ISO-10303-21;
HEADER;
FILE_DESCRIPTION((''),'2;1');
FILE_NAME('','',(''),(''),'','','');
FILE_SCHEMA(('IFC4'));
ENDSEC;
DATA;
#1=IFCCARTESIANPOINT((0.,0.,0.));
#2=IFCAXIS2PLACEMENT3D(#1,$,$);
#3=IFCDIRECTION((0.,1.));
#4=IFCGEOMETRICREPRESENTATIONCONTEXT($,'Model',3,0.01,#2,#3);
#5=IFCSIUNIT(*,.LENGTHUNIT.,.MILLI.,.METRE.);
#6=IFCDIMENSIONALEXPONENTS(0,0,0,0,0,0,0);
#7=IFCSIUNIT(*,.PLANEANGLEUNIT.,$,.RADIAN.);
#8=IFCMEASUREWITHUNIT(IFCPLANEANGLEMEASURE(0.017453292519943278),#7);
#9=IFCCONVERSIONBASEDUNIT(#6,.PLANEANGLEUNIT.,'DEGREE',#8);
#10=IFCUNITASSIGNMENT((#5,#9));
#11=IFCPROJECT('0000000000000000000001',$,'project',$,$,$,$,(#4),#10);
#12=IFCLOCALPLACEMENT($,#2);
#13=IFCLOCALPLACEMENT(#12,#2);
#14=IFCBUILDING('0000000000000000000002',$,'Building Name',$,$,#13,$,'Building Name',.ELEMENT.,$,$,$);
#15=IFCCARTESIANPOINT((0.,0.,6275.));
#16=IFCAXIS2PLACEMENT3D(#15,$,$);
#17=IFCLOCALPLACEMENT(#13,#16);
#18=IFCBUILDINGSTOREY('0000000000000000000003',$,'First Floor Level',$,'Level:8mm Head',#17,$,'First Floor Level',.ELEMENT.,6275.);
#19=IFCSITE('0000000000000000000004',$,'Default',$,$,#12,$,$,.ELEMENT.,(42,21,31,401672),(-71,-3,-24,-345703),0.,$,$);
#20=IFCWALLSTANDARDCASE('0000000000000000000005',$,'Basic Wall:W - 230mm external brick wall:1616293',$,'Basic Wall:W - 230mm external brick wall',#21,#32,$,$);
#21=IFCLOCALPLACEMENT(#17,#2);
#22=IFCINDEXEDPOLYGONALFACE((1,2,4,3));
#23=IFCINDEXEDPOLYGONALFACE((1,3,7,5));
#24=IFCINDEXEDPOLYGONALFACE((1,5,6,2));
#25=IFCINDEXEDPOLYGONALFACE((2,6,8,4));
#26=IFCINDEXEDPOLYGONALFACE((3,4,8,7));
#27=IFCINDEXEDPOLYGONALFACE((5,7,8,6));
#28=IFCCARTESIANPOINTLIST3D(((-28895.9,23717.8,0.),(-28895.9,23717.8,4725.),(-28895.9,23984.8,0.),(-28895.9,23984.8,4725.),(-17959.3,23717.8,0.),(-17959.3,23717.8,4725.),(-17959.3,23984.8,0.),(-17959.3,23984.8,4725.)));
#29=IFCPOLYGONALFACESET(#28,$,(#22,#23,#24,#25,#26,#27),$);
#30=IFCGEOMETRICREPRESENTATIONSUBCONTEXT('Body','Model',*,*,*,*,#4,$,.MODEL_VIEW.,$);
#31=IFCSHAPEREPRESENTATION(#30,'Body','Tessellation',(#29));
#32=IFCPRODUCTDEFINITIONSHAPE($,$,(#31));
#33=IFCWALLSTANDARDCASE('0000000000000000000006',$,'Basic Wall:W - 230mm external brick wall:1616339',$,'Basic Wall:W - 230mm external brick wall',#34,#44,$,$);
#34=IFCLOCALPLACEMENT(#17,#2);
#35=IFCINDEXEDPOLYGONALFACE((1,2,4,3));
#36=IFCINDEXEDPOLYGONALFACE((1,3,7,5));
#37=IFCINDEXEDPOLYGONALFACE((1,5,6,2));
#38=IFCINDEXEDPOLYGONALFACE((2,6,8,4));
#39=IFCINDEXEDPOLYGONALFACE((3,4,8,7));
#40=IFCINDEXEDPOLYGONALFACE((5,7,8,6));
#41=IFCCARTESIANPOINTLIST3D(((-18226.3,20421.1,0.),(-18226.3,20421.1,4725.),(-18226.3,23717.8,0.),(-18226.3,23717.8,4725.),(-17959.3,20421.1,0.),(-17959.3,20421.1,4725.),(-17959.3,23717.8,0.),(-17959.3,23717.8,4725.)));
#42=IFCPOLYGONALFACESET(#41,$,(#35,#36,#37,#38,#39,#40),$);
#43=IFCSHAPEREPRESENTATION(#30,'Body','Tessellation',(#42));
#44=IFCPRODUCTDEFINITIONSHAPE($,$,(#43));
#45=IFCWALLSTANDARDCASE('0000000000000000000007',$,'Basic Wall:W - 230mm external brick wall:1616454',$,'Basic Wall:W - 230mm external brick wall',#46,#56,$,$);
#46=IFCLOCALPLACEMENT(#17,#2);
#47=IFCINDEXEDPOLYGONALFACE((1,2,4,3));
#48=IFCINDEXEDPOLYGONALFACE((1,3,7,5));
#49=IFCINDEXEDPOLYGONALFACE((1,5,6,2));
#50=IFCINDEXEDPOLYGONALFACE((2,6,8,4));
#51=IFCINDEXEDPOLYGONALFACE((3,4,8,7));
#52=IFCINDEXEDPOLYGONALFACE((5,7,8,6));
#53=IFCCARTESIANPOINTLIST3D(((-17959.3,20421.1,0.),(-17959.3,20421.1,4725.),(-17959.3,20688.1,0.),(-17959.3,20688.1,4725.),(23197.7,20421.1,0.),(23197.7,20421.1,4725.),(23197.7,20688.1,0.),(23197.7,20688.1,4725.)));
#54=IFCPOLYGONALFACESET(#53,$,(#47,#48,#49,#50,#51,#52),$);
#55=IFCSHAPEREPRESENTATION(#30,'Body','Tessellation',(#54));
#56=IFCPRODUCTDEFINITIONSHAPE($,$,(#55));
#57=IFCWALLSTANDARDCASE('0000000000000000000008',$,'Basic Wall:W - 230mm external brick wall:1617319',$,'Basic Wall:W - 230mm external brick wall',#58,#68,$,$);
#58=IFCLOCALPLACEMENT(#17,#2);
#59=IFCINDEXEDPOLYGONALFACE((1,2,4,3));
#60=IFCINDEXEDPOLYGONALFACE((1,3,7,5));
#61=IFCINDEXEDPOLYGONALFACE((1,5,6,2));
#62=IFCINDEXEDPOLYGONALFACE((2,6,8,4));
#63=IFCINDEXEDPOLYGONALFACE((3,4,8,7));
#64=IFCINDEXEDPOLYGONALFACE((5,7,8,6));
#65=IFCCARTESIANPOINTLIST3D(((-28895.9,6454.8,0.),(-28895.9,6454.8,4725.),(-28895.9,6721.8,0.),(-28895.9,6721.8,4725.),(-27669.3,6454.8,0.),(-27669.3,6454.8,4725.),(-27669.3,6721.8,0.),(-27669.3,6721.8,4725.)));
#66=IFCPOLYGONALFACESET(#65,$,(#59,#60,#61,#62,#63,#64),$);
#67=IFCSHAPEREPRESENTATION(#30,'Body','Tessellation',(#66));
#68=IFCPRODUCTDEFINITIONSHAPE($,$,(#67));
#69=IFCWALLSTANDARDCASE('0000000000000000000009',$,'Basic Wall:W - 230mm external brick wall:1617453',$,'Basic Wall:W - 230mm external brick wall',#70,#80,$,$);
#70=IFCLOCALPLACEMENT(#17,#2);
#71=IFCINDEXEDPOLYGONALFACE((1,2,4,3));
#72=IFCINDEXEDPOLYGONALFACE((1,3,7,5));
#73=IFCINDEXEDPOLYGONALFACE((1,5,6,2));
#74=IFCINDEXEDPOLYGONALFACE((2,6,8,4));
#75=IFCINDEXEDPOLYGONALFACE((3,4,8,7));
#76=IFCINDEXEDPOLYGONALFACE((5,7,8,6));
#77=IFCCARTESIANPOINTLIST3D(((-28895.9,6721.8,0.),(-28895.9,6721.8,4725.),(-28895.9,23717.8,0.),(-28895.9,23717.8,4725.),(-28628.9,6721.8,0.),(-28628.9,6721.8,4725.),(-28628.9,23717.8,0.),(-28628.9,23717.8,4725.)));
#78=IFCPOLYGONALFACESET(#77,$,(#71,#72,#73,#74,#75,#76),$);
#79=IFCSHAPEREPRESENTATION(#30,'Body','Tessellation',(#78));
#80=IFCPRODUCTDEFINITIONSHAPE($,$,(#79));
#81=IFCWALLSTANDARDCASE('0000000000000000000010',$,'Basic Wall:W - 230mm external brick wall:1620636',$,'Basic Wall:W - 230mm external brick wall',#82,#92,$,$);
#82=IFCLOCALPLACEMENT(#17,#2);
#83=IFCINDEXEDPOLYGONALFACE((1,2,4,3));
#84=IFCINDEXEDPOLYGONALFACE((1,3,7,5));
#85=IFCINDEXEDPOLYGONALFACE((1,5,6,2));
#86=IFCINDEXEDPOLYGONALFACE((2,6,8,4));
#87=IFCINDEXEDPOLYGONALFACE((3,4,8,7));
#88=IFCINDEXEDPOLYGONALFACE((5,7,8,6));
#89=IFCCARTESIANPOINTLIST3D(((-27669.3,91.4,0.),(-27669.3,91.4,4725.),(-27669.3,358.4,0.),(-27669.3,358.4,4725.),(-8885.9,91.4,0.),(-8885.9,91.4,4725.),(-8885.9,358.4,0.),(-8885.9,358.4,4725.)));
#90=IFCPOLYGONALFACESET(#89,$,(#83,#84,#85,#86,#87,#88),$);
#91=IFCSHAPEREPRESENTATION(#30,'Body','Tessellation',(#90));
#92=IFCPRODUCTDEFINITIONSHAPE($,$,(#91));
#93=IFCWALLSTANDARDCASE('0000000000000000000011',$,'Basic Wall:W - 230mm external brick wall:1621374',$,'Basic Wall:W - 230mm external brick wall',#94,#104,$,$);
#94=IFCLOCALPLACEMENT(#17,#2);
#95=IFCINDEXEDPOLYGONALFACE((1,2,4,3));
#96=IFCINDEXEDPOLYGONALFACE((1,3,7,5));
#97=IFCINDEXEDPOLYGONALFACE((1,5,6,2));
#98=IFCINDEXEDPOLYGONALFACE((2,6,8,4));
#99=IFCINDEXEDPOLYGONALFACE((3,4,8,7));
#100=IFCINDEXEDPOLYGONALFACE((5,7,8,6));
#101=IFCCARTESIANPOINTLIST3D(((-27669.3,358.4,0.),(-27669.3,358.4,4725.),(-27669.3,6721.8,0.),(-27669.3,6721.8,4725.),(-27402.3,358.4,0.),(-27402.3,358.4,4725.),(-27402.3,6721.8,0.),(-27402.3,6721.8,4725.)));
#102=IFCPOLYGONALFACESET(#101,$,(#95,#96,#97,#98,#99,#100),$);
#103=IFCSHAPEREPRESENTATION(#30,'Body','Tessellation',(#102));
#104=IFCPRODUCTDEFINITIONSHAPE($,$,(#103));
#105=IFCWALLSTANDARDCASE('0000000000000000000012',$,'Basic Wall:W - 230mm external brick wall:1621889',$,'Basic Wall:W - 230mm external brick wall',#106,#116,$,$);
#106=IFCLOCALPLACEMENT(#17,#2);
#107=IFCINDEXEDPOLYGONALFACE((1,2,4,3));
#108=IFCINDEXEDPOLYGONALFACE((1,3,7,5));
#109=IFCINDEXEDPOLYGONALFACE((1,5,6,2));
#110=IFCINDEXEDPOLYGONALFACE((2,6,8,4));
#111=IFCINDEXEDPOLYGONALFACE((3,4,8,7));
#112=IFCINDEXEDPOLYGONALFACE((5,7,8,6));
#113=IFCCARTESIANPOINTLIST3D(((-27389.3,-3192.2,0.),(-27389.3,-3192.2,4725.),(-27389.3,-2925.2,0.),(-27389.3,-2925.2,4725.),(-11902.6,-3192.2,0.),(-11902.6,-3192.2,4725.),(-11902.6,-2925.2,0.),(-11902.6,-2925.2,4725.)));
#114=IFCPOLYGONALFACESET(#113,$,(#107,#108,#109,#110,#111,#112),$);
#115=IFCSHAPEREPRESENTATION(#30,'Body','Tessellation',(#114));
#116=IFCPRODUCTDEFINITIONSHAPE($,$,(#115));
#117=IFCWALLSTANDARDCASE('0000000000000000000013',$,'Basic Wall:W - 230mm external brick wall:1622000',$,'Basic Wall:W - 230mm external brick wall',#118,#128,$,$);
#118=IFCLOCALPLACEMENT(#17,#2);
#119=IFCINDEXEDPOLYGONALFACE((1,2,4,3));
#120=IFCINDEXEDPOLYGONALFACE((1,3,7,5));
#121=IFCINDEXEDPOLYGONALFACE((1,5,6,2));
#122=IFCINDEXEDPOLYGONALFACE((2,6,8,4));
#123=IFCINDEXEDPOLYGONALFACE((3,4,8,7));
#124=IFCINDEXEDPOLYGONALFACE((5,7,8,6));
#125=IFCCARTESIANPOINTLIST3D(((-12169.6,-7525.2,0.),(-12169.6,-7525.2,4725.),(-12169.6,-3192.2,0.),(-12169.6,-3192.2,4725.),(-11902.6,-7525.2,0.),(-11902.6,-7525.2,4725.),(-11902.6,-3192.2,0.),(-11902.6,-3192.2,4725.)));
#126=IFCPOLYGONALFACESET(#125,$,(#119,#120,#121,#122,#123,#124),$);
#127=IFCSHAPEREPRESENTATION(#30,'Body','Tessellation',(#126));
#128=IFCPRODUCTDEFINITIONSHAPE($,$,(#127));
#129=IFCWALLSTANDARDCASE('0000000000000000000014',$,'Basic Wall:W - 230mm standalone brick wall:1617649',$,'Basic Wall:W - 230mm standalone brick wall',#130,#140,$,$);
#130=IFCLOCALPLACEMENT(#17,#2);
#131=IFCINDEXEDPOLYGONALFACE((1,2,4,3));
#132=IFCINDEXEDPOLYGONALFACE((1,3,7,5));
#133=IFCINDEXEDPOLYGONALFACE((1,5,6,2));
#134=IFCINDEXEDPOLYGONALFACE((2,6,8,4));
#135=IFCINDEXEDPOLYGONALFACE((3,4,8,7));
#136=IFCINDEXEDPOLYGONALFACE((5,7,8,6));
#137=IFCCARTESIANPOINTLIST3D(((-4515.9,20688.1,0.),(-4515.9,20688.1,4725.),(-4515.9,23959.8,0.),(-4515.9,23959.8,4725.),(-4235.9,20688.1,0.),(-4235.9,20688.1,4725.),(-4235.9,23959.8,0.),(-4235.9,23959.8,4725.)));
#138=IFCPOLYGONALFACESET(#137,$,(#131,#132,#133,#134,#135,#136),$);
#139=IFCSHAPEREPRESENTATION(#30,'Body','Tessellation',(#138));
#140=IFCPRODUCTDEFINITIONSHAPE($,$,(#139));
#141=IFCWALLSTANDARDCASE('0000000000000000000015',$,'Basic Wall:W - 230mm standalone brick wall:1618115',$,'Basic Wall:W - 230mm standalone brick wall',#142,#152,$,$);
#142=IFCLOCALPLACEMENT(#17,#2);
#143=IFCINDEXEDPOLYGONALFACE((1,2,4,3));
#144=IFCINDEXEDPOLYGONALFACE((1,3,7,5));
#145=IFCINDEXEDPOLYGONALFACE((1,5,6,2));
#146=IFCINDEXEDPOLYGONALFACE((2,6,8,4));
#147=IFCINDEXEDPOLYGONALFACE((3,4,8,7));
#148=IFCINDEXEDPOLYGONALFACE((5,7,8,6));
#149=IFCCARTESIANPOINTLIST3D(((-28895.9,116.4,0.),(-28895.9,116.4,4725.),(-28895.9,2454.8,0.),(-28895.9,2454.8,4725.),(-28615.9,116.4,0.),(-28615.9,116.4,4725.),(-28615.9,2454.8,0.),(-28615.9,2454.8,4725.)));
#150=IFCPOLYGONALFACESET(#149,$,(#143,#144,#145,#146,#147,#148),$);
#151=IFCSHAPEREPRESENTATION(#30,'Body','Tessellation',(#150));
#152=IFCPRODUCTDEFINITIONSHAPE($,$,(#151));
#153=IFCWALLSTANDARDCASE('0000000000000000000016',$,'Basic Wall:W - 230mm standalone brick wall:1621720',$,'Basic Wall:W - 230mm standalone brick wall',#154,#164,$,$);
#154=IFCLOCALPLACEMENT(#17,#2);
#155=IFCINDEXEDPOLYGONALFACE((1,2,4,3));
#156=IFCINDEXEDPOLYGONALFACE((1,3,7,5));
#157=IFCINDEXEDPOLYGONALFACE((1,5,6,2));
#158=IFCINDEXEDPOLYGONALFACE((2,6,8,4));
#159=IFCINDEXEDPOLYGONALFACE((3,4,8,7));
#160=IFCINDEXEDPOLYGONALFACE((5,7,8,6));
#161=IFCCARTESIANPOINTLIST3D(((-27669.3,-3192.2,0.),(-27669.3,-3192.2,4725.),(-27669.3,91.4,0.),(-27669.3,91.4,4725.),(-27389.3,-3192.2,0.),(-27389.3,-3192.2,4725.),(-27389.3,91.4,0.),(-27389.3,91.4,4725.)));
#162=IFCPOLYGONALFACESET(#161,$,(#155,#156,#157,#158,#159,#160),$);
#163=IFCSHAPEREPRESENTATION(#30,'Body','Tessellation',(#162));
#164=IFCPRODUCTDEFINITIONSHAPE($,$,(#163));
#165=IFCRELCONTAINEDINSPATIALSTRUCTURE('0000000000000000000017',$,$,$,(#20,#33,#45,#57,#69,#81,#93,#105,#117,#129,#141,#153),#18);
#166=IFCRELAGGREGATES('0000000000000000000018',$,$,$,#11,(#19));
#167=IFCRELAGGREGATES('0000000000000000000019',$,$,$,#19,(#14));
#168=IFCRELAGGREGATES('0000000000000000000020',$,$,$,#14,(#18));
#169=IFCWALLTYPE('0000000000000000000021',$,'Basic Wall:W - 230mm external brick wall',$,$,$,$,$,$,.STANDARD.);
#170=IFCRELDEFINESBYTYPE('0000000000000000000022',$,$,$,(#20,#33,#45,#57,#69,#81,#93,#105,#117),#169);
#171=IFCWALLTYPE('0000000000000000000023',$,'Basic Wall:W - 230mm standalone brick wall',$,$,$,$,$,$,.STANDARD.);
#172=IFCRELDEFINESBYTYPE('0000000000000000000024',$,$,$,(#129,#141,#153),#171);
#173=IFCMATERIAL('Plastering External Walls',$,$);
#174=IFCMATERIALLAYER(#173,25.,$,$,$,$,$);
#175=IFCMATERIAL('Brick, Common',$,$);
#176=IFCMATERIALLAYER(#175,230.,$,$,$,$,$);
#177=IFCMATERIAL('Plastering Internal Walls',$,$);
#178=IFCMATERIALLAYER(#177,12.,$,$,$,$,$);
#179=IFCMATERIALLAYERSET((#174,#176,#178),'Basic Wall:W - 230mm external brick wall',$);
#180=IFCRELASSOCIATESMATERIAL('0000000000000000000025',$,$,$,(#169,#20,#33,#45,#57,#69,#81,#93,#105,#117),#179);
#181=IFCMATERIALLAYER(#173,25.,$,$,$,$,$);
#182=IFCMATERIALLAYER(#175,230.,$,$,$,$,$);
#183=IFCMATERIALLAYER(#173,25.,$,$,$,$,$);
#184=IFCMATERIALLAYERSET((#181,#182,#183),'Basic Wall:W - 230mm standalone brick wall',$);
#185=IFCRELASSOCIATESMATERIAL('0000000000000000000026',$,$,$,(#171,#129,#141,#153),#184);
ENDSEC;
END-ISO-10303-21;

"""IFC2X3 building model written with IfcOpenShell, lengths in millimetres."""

from ifc_helpers import new_model, entity, si_unit, converted_unit, direction, frame, frame_2d, origin, place, context, subcontext, project, spatial, rectangle, extrude, material, layer, layer_set, layer_usage, type_object, element, save


model = new_model("IFC2X3")

# Units and contexts
model_context = context("Model", 3, precision=0.01, world=origin(), true_north=direction((0.0, 1.0)))
body_context = subcontext(model_context, "Body", "Model", "MODEL_VIEW")
ifc_project = project(units=[si_unit("LENGTHUNIT", "METRE", prefix="MILLI"), converted_unit("PLANEANGLEUNIT", "DEGREE", entity("IfcPlaneAngleMeasure", 0.017453292519943278), si_unit("PLANEANGLEUNIT", "RADIAN"), dimensions=[0, 0, 0, 0, 0, 0, 0])], contexts=[model_context])

# Site, building, storey
site_placement = place(None, origin())
site = spatial("IfcSite", under=ifc_project, at=site_placement, Name="Default", CompositionType="ELEMENT", RefLatitude=(42, 21, 31, 401672), RefLongitude=(-71, -3, -24, -345703), RefElevation=0.0)
building_placement = place(site_placement, origin())
building = spatial("IfcBuilding", under=site, at=building_placement, Name="Building Name", LongName="Building Name", CompositionType="ELEMENT")
storey_placement = place(building_placement, frame((0.0, 0.0, 6275.0)))
storey = spatial("IfcBuildingStorey", under=building, at=storey_placement, Name="First Floor Level", ObjectType="Level:8mm Head", LongName="First Floor Level", CompositionType="ELEMENT", Elevation=6275.0)

# Walls
ifc_material_1 = material(Name="Plastering External Walls")
ifc_layer_1 = layer(ifc_material_1, 25.0)
ifc_material_2 = material(Name="Brick, Common")
ifc_layer_2 = layer(ifc_material_2, 230.0)
ifc_material_3 = material(Name="Plastering Internal Walls")
ifc_layer_3 = layer(ifc_material_3, 12.0)
ifc_layer_set_1 = layer_set([ifc_layer_1, ifc_layer_2, ifc_layer_3], Name="Basic Wall:W - 230mm external brick wall")
ifc_layer_usage_1 = layer_usage(ifc_layer_set_1, "AXIS2", "NEGATIVE", 133.5)
wall_type_1 = type_object("IfcWallType", Name="Basic Wall:W - 230mm external brick wall", PredefinedType="STANDARD", material=ifc_layer_set_1)
wall_1_placement = place(storey_placement, frame((-28895.9, 23851.3, 0.0)))
element("IfcWallStandardCase", 1, at=wall_1_placement, inside=storey, type_object=wall_type_1, material=ifc_layer_usage_1, Name="Basic Wall:W - 230mm external brick wall:1616293", ObjectType="Basic Wall:W - 230mm external brick wall", context=body_context, shape_type="SweptSolid", body=[
    extrude(rectangle(XDim=10936.7, YDim=267.0, at=frame_2d((5468.3, 0.0), x_axis=(-1.0, 0.0))), origin(), (0.0, 0.0, 1.0), 4725.0),
])
ifc_layer_usage_2 = layer_usage(ifc_layer_set_1, "AXIS2", "NEGATIVE", 133.5)
wall_2_placement = place(storey_placement, frame((-18092.8, 23717.8, 0.0), z_axis=(0.0, 0.0, 1.0), x_axis=(0.0, -1.0, 0.0)))
element("IfcWallStandardCase", 2, at=wall_2_placement, inside=storey, type_object=wall_type_1, material=ifc_layer_usage_2, Name="Basic Wall:W - 230mm external brick wall:1616339", ObjectType="Basic Wall:W - 230mm external brick wall", context=body_context, shape_type="SweptSolid", body=[
    extrude(rectangle(XDim=3296.7, YDim=267.0, at=frame_2d((1648.3, 0.0), x_axis=(-1.0, 0.0))), origin(), (0.0, 0.0, 1.0), 4725.0),
])
ifc_layer_usage_3 = layer_usage(ifc_layer_set_1, "AXIS2", "NEGATIVE", 133.5)
wall_3_placement = place(storey_placement, frame((-17959.3, 20554.6, 0.0)))
element("IfcWallStandardCase", 3, at=wall_3_placement, inside=storey, type_object=wall_type_1, material=ifc_layer_usage_3, Name="Basic Wall:W - 230mm external brick wall:1616454", ObjectType="Basic Wall:W - 230mm external brick wall", context=body_context, shape_type="SweptSolid", body=[
    extrude(rectangle(XDim=41157.0, YDim=267.0, at=frame_2d((20578.5, 0.0), x_axis=(-1.0, 0.0))), origin(), (0.0, 0.0, 1.0), 4725.0),
])
ifc_layer_usage_4 = layer_usage(ifc_layer_set_1, "AXIS2", "NEGATIVE", 133.5)
wall_4_placement = place(storey_placement, frame((-27669.3, 6588.3, 0.0), z_axis=(0.0, 0.0, 1.0), x_axis=(-1.0, 0.0, 0.0)))
element("IfcWallStandardCase", 4, at=wall_4_placement, inside=storey, type_object=wall_type_1, material=ifc_layer_usage_4, Name="Basic Wall:W - 230mm external brick wall:1617319", ObjectType="Basic Wall:W - 230mm external brick wall", context=body_context, shape_type="SweptSolid", body=[
    extrude(rectangle(XDim=1226.7, YDim=267.0, at=frame_2d((613.3, 0.0), x_axis=(-1.0, 0.0))), origin(), (0.0, 0.0, 1.0), 4725.0),
])
ifc_layer_usage_5 = layer_usage(ifc_layer_set_1, "AXIS2", "NEGATIVE", 133.5)
wall_5_placement = place(storey_placement, frame((-28762.4, 6721.8, 0.0), z_axis=(0.0, 0.0, 1.0), x_axis=(0.0, 1.0, 0.0)))
element("IfcWallStandardCase", 5, at=wall_5_placement, inside=storey, type_object=wall_type_1, material=ifc_layer_usage_5, Name="Basic Wall:W - 230mm external brick wall:1617453", ObjectType="Basic Wall:W - 230mm external brick wall", context=body_context, shape_type="SweptSolid", body=[
    extrude(rectangle(XDim=16996.0, YDim=267.0, at=frame_2d((8498.0, 0.0), x_axis=(-1.0, 0.0))), origin(), (0.0, 0.0, 1.0), 4725.0),
])
ifc_layer_usage_6 = layer_usage(ifc_layer_set_1, "AXIS2", "NEGATIVE", 133.5)
wall_6_placement = place(storey_placement, frame((-8885.9, 224.9, 0.0), z_axis=(0.0, 0.0, 1.0), x_axis=(-1.0, 0.0, 0.0)))
element("IfcWallStandardCase", 6, at=wall_6_placement, inside=storey, type_object=wall_type_1, material=ifc_layer_usage_6, Name="Basic Wall:W - 230mm external brick wall:1620636", ObjectType="Basic Wall:W - 230mm external brick wall", context=body_context, shape_type="SweptSolid", body=[
    extrude(rectangle(XDim=18783.3, YDim=267.0, at=frame_2d((9391.7, 0.0), x_axis=(-1.0, 0.0))), origin(), (0.0, 0.0, 1.0), 4725.0),
])
ifc_layer_usage_7 = layer_usage(ifc_layer_set_1, "AXIS2", "NEGATIVE", 133.5)
wall_7_placement = place(storey_placement, frame((-27535.8, 358.4, 0.0), z_axis=(0.0, 0.0, 1.0), x_axis=(0.0, 1.0, 0.0)))
element("IfcWallStandardCase", 7, at=wall_7_placement, inside=storey, type_object=wall_type_1, material=ifc_layer_usage_7, Name="Basic Wall:W - 230mm external brick wall:1621374", ObjectType="Basic Wall:W - 230mm external brick wall", context=body_context, shape_type="SweptSolid", body=[
    extrude(rectangle(XDim=6363.3, YDim=267.0, at=frame_2d((3181.7, 0.0), x_axis=(-1.0, 0.0))), origin(), (0.0, 0.0, 1.0), 4725.0),
])
ifc_layer_usage_8 = layer_usage(ifc_layer_set_1, "AXIS2", "NEGATIVE", 133.5)
wall_8_placement = place(storey_placement, frame((-27389.3, -3058.7, 0.0)))
element("IfcWallStandardCase", 8, at=wall_8_placement, inside=storey, type_object=wall_type_1, material=ifc_layer_usage_8, Name="Basic Wall:W - 230mm external brick wall:1621889", ObjectType="Basic Wall:W - 230mm external brick wall", context=body_context, shape_type="SweptSolid", body=[
    extrude(rectangle(XDim=15486.7, YDim=267.0, at=frame_2d((7743.3, 0.0), x_axis=(-1.0, 0.0))), origin(), (0.0, 0.0, 1.0), 4725.0),
])
ifc_layer_usage_9 = layer_usage(ifc_layer_set_1, "AXIS2", "NEGATIVE", 133.5)
wall_9_placement = place(storey_placement, frame((-12036.1, -3192.2, 0.0), z_axis=(0.0, 0.0, 1.0), x_axis=(0.0, -1.0, 0.0)))
element("IfcWallStandardCase", 9, at=wall_9_placement, inside=storey, type_object=wall_type_1, material=ifc_layer_usage_9, Name="Basic Wall:W - 230mm external brick wall:1622000", ObjectType="Basic Wall:W - 230mm external brick wall", context=body_context, shape_type="SweptSolid", body=[
    extrude(rectangle(XDim=4333.0, YDim=267.0, at=frame_2d((2166.5, 0.0), x_axis=(-1.0, 0.0))), origin(), (0.0, 0.0, 1.0), 4725.0),
])
ifc_layer_4 = layer(ifc_material_1, 25.0)
ifc_layer_5 = layer(ifc_material_2, 230.0)
ifc_layer_6 = layer(ifc_material_1, 25.0)
ifc_layer_set_2 = layer_set([ifc_layer_4, ifc_layer_5, ifc_layer_6], Name="Basic Wall:W - 230mm standalone brick wall")
ifc_layer_usage_10 = layer_usage(ifc_layer_set_2, "AXIS2", "NEGATIVE", 140.0)
wall_type_2 = type_object("IfcWallType", Name="Basic Wall:W - 230mm standalone brick wall", PredefinedType="STANDARD", material=ifc_layer_set_2)
wall_10_placement = place(storey_placement, frame((-4375.9, 20688.1, 0.0), z_axis=(0.0, 0.0, 1.0), x_axis=(0.0, 1.0, 0.0)))
element("IfcWallStandardCase", 10, at=wall_10_placement, inside=storey, type_object=wall_type_2, material=ifc_layer_usage_10, Name="Basic Wall:W - 230mm standalone brick wall:1617649", ObjectType="Basic Wall:W - 230mm standalone brick wall", context=body_context, shape_type="SweptSolid", body=[
    extrude(rectangle(XDim=3271.7, YDim=280.0, at=frame_2d((1635.8, 0.0), x_axis=(-1.0, 0.0))), origin(), (0.0, 0.0, 1.0), 4725.0),
])
ifc_layer_usage_11 = layer_usage(ifc_layer_set_2, "AXIS2", "NEGATIVE", 140.0)
wall_11_placement = place(storey_placement, frame((-28755.9, 116.4, 0.0), z_axis=(0.0, 0.0, 1.0), x_axis=(0.0, 1.0, 0.0)))
element("IfcWallStandardCase", 11, at=wall_11_placement, inside=storey, type_object=wall_type_2, material=ifc_layer_usage_11, Name="Basic Wall:W - 230mm standalone brick wall:1618115", ObjectType="Basic Wall:W - 230mm standalone brick wall", context=body_context, shape_type="SweptSolid", body=[
    extrude(rectangle(XDim=2338.3, YDim=280.0, at=frame_2d((1169.2, 0.0), x_axis=(-1.0, 0.0))), origin(), (0.0, 0.0, 1.0), 4725.0),
])
ifc_layer_usage_12 = layer_usage(ifc_layer_set_2, "AXIS2", "NEGATIVE", 140.0)
wall_12_placement = place(storey_placement, frame((-27529.3, -3192.2, 0.0), z_axis=(0.0, 0.0, 1.0), x_axis=(0.0, 1.0, 0.0)))
element("IfcWallStandardCase", 12, at=wall_12_placement, inside=storey, type_object=wall_type_2, material=ifc_layer_usage_12, Name="Basic Wall:W - 230mm standalone brick wall:1621720", ObjectType="Basic Wall:W - 230mm standalone brick wall", context=body_context, shape_type="SweptSolid", body=[
    extrude(rectangle(XDim=3283.7, YDim=280.0, at=frame_2d((1641.8, 0.0), x_axis=(-1.0, 0.0))), origin(), (0.0, 0.0, 1.0), 4725.0),
])

save(model, "model.ifc")
